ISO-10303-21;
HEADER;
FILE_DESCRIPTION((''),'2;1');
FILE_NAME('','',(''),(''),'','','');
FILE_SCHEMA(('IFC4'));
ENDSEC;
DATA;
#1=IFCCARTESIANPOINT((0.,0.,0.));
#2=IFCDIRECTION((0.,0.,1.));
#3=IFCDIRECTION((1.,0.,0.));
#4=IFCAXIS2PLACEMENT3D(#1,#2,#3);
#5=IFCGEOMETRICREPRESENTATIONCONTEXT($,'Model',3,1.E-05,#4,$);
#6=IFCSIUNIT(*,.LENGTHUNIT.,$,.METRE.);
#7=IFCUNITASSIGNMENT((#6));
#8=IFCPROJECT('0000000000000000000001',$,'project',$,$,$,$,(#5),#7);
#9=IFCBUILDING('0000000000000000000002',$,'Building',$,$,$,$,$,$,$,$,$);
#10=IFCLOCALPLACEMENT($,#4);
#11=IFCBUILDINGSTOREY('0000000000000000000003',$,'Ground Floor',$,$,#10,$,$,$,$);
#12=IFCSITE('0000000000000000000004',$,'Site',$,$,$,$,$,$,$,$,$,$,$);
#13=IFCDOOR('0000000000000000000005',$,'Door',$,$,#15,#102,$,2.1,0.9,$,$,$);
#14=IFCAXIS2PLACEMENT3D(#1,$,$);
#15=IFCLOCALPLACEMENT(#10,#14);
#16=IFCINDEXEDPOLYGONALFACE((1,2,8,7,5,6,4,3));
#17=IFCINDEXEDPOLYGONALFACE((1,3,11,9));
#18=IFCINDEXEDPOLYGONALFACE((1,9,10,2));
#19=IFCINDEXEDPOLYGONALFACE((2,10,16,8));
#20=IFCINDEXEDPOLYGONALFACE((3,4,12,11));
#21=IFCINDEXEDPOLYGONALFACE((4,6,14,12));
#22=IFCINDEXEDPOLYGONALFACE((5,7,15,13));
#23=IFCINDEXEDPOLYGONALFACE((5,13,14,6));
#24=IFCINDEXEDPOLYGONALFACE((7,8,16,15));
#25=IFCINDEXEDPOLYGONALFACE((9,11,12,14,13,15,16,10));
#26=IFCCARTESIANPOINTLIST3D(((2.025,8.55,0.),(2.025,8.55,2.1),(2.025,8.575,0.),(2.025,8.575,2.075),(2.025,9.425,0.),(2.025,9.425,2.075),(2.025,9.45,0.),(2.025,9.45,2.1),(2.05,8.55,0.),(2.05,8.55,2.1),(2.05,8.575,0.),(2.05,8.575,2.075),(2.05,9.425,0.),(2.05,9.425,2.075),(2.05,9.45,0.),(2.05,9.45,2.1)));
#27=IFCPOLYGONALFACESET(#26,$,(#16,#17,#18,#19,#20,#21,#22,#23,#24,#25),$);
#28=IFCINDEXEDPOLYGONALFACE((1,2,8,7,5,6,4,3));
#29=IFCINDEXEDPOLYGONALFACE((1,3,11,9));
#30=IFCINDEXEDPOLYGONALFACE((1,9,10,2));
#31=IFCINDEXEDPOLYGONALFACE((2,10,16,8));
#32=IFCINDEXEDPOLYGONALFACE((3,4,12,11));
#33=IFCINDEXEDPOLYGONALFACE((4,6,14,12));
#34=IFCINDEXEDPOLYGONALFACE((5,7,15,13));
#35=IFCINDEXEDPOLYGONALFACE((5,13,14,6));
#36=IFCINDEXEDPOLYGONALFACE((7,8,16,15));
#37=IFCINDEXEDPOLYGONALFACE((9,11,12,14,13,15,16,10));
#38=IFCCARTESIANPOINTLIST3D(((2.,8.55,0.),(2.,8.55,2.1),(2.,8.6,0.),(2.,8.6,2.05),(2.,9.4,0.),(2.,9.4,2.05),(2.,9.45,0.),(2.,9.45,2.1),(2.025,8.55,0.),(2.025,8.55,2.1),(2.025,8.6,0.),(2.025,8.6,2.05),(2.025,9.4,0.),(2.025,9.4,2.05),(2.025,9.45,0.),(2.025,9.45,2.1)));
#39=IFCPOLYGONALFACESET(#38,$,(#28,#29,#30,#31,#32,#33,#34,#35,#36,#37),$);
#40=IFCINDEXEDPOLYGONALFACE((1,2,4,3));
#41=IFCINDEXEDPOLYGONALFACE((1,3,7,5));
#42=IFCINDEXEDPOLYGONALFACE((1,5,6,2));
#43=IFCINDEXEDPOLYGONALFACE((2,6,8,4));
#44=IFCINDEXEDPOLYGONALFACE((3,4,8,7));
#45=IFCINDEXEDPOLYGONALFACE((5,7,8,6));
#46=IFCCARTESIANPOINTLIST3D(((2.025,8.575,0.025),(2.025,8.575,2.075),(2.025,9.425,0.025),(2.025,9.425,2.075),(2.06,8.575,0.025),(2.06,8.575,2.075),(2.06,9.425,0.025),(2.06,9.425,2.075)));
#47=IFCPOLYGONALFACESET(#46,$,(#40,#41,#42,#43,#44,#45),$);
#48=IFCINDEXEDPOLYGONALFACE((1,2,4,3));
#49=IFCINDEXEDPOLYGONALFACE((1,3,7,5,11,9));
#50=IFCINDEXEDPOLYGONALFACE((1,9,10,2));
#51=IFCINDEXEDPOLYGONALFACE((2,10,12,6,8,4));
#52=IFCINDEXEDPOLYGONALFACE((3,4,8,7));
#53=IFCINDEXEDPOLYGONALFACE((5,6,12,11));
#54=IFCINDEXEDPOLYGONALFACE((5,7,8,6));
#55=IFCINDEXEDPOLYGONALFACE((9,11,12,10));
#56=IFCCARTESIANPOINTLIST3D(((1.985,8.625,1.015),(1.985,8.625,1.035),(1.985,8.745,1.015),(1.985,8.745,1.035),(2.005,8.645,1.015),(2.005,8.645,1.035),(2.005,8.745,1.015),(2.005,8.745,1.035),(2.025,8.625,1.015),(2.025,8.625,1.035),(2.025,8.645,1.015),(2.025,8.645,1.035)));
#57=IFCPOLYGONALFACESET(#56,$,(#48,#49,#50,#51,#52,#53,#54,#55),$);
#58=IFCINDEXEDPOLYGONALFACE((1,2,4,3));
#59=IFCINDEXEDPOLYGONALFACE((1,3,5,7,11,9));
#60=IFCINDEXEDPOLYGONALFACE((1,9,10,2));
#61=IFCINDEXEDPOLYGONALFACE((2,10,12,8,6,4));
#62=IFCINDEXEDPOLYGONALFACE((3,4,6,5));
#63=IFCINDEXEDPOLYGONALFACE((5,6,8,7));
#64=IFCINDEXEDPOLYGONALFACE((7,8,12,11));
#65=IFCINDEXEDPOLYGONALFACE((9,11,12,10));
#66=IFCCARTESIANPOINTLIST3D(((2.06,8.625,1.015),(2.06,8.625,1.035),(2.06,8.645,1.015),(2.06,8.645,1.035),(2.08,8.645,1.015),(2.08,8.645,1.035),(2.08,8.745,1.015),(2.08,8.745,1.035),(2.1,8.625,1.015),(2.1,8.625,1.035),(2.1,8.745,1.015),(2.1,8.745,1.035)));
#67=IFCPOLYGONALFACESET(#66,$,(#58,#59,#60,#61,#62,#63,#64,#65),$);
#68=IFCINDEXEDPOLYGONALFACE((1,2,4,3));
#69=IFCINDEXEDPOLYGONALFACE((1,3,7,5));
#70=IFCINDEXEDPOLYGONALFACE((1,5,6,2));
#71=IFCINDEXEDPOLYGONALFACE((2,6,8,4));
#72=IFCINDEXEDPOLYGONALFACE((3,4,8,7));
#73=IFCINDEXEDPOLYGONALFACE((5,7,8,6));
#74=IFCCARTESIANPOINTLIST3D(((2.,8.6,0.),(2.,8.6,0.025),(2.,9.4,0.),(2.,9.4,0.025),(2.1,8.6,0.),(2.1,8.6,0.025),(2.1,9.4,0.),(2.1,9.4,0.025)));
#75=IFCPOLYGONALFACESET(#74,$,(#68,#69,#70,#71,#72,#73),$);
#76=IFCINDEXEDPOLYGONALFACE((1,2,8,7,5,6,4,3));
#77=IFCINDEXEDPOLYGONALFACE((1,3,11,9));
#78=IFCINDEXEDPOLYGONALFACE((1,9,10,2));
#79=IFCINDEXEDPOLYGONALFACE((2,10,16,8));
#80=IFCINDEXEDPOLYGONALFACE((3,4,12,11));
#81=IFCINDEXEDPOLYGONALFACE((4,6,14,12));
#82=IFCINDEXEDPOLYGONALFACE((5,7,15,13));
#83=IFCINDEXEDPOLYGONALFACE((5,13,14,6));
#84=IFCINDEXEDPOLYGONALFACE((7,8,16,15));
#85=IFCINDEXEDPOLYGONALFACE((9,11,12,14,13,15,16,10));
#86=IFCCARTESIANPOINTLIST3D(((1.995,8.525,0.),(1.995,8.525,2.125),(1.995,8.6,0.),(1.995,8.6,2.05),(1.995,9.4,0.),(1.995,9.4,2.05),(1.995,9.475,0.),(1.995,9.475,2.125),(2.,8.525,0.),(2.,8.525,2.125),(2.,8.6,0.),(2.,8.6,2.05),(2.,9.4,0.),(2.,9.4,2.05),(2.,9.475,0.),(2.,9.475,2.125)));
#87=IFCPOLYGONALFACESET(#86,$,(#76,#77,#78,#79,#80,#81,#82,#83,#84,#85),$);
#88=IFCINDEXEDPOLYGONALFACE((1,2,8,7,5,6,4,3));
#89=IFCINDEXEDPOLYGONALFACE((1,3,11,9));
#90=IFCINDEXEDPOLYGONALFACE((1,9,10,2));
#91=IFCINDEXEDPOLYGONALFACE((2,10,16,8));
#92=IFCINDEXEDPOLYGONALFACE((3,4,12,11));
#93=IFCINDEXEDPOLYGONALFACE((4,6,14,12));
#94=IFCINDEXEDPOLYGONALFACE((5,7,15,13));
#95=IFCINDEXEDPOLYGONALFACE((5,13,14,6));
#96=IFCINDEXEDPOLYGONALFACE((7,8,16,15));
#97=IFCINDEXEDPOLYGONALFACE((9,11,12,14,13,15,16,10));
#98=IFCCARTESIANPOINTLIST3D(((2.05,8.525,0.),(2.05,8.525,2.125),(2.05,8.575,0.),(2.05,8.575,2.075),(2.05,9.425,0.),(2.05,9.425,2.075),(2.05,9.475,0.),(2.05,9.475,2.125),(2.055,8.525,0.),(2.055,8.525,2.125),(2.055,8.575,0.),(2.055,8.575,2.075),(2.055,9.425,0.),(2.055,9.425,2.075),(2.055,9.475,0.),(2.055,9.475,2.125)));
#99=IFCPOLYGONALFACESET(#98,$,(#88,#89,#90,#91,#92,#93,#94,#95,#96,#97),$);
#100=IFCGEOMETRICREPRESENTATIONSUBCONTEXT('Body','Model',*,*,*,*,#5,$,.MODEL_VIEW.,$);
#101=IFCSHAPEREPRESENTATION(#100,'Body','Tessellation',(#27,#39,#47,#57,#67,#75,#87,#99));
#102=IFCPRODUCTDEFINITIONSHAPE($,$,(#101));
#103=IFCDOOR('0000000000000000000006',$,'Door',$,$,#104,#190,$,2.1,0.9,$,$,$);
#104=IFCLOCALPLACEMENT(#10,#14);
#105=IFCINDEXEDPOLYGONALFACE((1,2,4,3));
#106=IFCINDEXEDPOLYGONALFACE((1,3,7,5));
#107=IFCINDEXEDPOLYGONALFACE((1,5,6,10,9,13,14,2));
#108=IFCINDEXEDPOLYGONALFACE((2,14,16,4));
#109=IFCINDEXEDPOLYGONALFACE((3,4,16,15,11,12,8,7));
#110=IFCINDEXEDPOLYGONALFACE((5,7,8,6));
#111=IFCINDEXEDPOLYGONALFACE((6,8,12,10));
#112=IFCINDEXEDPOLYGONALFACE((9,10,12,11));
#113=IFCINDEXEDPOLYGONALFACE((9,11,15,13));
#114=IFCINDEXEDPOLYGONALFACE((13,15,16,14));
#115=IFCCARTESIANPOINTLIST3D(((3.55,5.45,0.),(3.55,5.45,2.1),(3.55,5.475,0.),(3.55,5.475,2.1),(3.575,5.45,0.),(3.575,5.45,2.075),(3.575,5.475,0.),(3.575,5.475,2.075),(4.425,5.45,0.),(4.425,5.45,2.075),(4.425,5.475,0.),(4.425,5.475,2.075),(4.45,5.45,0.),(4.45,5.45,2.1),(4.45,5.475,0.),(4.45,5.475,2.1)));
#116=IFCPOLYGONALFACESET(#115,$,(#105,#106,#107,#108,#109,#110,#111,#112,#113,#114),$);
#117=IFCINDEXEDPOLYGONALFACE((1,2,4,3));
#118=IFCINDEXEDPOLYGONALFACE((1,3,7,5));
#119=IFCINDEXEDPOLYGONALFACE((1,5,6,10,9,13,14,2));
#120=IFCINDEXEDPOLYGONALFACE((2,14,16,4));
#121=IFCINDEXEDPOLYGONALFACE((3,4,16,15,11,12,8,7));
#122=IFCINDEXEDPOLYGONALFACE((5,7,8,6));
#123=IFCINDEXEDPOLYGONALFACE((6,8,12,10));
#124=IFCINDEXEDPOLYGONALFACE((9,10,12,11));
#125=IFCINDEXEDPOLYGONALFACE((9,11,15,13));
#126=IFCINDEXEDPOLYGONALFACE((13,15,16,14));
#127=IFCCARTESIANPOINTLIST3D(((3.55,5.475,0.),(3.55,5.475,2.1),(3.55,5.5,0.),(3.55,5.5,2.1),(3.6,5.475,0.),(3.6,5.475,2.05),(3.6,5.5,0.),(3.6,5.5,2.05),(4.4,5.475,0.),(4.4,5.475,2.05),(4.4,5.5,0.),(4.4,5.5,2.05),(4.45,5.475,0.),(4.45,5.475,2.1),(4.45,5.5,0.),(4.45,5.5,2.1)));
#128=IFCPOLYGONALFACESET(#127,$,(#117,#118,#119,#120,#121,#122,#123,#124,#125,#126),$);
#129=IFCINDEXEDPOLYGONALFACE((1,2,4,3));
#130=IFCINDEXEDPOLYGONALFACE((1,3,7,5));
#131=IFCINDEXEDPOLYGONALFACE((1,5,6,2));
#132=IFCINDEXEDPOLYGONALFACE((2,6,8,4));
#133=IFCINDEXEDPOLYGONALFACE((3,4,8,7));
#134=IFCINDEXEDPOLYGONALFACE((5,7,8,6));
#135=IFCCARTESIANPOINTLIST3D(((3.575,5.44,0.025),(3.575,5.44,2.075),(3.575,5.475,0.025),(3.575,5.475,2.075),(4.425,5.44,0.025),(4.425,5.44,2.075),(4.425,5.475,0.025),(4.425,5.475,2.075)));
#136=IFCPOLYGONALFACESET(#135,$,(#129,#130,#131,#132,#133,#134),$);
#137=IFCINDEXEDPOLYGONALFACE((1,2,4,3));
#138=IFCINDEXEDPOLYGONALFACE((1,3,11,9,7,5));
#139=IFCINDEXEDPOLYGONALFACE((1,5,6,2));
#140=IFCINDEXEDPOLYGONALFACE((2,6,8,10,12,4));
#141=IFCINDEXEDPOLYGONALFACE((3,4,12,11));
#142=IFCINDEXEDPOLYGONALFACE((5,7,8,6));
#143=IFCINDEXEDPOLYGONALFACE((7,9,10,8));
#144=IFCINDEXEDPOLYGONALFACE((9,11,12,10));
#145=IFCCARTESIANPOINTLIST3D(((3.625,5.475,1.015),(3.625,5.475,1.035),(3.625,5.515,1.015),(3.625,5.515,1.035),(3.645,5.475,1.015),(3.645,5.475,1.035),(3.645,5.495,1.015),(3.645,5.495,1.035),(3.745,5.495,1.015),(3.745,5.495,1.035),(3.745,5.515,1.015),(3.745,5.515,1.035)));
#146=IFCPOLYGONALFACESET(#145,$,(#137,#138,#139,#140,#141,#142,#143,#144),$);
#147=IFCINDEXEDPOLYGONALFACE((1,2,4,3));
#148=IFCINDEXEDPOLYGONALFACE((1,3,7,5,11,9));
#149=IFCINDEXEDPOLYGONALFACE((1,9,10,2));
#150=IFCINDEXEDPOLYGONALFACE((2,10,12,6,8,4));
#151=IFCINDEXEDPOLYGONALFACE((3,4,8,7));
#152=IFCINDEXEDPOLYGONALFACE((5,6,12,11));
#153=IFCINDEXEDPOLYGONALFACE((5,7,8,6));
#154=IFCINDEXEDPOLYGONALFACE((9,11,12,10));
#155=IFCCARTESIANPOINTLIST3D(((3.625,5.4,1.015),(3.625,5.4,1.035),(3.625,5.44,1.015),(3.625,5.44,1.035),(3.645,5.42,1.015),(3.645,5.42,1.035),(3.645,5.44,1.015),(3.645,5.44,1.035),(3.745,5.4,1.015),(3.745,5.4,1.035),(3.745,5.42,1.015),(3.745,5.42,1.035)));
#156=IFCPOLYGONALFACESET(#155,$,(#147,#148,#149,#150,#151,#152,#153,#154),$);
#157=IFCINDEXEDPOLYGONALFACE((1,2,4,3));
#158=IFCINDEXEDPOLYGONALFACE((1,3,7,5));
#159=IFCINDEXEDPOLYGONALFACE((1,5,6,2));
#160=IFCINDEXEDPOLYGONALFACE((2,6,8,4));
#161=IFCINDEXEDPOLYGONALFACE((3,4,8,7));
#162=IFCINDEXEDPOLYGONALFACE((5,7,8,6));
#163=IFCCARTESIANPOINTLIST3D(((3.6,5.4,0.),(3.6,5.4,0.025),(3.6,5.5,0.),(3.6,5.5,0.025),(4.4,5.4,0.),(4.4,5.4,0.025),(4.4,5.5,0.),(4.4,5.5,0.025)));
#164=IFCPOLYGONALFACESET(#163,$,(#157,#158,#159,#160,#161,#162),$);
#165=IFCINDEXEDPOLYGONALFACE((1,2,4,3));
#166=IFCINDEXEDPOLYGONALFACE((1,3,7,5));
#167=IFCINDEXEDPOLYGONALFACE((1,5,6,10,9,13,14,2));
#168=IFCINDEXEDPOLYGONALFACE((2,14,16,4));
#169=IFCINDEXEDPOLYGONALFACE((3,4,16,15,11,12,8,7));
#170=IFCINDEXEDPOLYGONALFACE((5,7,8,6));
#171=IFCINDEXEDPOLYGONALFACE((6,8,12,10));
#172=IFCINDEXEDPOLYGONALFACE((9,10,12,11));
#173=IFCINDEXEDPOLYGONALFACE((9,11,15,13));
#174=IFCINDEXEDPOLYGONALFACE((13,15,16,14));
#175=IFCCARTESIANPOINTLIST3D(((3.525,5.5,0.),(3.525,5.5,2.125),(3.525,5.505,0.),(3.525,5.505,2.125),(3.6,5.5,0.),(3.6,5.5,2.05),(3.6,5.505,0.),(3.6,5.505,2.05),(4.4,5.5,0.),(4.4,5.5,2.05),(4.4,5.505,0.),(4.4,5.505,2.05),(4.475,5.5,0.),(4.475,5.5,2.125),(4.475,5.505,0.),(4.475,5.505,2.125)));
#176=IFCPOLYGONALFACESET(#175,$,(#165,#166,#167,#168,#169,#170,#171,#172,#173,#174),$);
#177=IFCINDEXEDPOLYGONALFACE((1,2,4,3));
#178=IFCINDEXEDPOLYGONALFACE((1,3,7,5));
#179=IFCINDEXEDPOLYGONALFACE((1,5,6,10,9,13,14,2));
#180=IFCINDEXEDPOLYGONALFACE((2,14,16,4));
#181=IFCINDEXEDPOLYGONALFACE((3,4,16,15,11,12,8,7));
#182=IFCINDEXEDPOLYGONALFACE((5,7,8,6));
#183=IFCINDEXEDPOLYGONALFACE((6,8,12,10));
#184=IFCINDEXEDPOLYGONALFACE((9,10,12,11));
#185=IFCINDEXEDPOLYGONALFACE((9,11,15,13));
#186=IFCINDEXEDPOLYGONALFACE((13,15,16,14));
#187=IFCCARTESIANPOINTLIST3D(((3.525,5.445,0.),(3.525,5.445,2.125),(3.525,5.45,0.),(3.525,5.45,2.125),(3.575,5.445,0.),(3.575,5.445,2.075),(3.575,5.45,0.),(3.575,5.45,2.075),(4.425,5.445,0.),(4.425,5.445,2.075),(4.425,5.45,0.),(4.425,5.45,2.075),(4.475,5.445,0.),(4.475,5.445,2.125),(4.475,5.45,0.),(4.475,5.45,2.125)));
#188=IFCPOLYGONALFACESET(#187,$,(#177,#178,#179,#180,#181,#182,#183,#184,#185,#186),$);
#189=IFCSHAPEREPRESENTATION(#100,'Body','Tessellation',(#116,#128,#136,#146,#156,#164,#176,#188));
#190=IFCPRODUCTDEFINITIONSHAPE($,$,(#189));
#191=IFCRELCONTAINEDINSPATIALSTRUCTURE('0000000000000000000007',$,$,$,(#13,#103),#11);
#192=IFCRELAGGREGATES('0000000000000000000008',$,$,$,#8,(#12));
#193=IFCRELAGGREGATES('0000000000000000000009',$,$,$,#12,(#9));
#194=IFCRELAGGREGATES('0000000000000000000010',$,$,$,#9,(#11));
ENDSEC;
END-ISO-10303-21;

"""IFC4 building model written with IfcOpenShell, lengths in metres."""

from ifc_helpers import new_model, si_unit, frame, origin_with_axes, place, context, subcontext, project, spatial, line, indexed_curve, outline, extrude, element, save


model = new_model("IFC4")

# Units and contexts
model_context = context("Model", 3, precision=1e-05, world=origin_with_axes())
body_context = subcontext(model_context, "Body", "Model", "MODEL_VIEW")
ifc_project = project(units=[si_unit("LENGTHUNIT", "METRE")], contexts=[model_context])

# Site, building, storey
site = spatial("IfcSite", under=ifc_project, Name="Site")
building = spatial("IfcBuilding", under=site, Name="Building")
storey_placement = place(None, origin_with_axes())
storey = spatial("IfcBuildingStorey", under=building, at=storey_placement, Name="Ground Floor")

# Doors
door_1_placement = place(storey_placement, frame((2.0, 9.45, 0.0), z_axis=(0.0, 0.0, 1.0), x_axis=(0.0, -1.0, 0.0)))
element("IfcDoor", 1, at=door_1_placement, inside=storey, Name="Door", OverallHeight=2.1, OverallWidth=0.9, context=body_context, shape_type="SweptSolid", body=[
    extrude(outline(indexed_curve([(0.0, 0.0), (0.0, 2.1), (0.9, 2.1), (0.9, 0.0), (0.875, 0.0), (0.875, 2.075), (0.025, 2.075), (0.025, 0.0)], segments=[line(1, 2, 3, 4, 5, 6, 7, 8, 1)])), frame((0.0, 0.025, 0.0), z_axis=(0.0, -1.0, 0.0), x_axis=(1.0, 0.0, 0.0)), (0.0, 0.0, -1.0), 0.025),
    extrude(outline(indexed_curve([(0.0, 0.0), (0.0, 2.1), (0.9, 2.1), (0.9, 0.0), (0.85, 0.0), (0.85, 2.05), (0.05, 2.05), (0.05, 0.0)], segments=[line(1, 2, 3, 4, 5, 6, 7, 8, 1)])), frame((0.0, 0.0, 0.0), z_axis=(0.0, -1.0, 0.0), x_axis=(1.0, 0.0, 0.0)), (0.0, 0.0, -1.0), 0.025),
    extrude(outline(indexed_curve([(0.0, 0.0), (0.85, 0.0), (0.85, 0.035), (0.0, 0.035)], segments=[line(1, 2, 3, 4, 1)])), frame((0.025, 0.025, 0.025), z_axis=(0.0, 0.0, 1.0), x_axis=(1.0, 0.0, 0.0)), (0.0, 0.0, 1.0), 2.05),
    extrude(outline(indexed_curve([(0.0, 0.0), (0.0, -0.04), (-0.12, -0.04), (-0.12, -0.02), (-0.02, -0.02), (-0.02, 0.0)], segments=[line(1, 2, 3, 4, 5, 6, 1)])), frame((0.825, 0.025, 1.015), z_axis=(0.0, 0.0, 1.0), x_axis=(1.0, 0.0, 0.0)), (0.0, 0.0, 1.0), 0.02),
    extrude(outline(indexed_curve([(0.0, 0.0), (0.0, 0.04), (-0.12, 0.04), (-0.12, 0.02), (-0.02, 0.02), (-0.02, 0.0)], segments=[line(1, 2, 3, 4, 5, 6, 1)])), frame((0.825, 0.06, 1.015), z_axis=(0.0, 0.0, 1.0), x_axis=(1.0, 0.0, 0.0)), (0.0, 0.0, 1.0), 0.02),
    extrude(outline(indexed_curve([(0.0, 0.0), (0.8, 0.0), (0.8, 0.1), (0.0, 0.1)], segments=[line(1, 2, 3, 4, 1)])), frame((0.05, 0.0, 0.0), z_axis=(0.0, 0.0, 1.0), x_axis=(1.0, 0.0, 0.0)), (0.0, 0.0, 1.0), 0.025),
    extrude(outline(indexed_curve([(0.0, 0.0), (0.0, 2.125), (0.95, 2.125), (0.95, 0.0), (0.875, 0.0), (0.875, 2.05), (0.075, 2.05), (0.075, 0.0)], segments=[line(1, 2, 3, 4, 5, 6, 7, 8, 1)])), frame((-0.025, -0.005, 0.0), z_axis=(0.0, -1.0, 0.0), x_axis=(1.0, 0.0, 0.0)), (0.0, 0.0, -1.0), 0.005),
    extrude(outline(indexed_curve([(0.0, 0.0), (0.0, 2.125), (0.95, 2.125), (0.95, 0.0), (0.9, 0.0), (0.9, 2.075), (0.05, 2.075), (0.05, 0.0)], segments=[line(1, 2, 3, 4, 5, 6, 7, 8, 1)])), frame((-0.025, 0.05, 0.0), z_axis=(0.0, -1.0, 0.0), x_axis=(1.0, 0.0, 0.0)), (0.0, 0.0, -1.0), 0.005),
])
door_2_placement = place(storey_placement, frame((4.45, 5.5, 0.0), z_axis=(0.0, 0.0, 1.0), x_axis=(-1.0, 0.0, 0.0)))
element("IfcDoor", 2, at=door_2_placement, inside=storey, Name="Door", OverallHeight=2.1, OverallWidth=0.9, context=body_context, shape_type="SweptSolid", body=[
    extrude(outline(indexed_curve([(0.0, 0.0), (0.0, 2.1), (0.9, 2.1), (0.9, 0.0), (0.875, 0.0), (0.875, 2.075), (0.025, 2.075), (0.025, 0.0)], segments=[line(1, 2, 3, 4, 5, 6, 7, 8, 1)])), frame((0.0, 0.025, 0.0), z_axis=(0.0, -1.0, 0.0), x_axis=(1.0, 0.0, 0.0)), (0.0, 0.0, -1.0), 0.025),
    extrude(outline(indexed_curve([(0.0, 0.0), (0.0, 2.1), (0.9, 2.1), (0.9, 0.0), (0.85, 0.0), (0.85, 2.05), (0.05, 2.05), (0.05, 0.0)], segments=[line(1, 2, 3, 4, 5, 6, 7, 8, 1)])), frame((0.0, 0.0, 0.0), z_axis=(0.0, -1.0, 0.0), x_axis=(1.0, 0.0, 0.0)), (0.0, 0.0, -1.0), 0.025),
    extrude(outline(indexed_curve([(0.0, 0.0), (0.85, 0.0), (0.85, 0.035), (0.0, 0.035)], segments=[line(1, 2, 3, 4, 1)])), frame((0.025, 0.025, 0.025), z_axis=(0.0, 0.0, 1.0), x_axis=(1.0, 0.0, 0.0)), (0.0, 0.0, 1.0), 2.05),
    extrude(outline(indexed_curve([(0.0, 0.0), (0.0, -0.04), (-0.12, -0.04), (-0.12, -0.02), (-0.02, -0.02), (-0.02, 0.0)], segments=[line(1, 2, 3, 4, 5, 6, 1)])), frame((0.825, 0.025, 1.015), z_axis=(0.0, 0.0, 1.0), x_axis=(1.0, 0.0, 0.0)), (0.0, 0.0, 1.0), 0.02),
    extrude(outline(indexed_curve([(0.0, 0.0), (0.0, 0.04), (-0.12, 0.04), (-0.12, 0.02), (-0.02, 0.02), (-0.02, 0.0)], segments=[line(1, 2, 3, 4, 5, 6, 1)])), frame((0.825, 0.06, 1.015), z_axis=(0.0, 0.0, 1.0), x_axis=(1.0, 0.0, 0.0)), (0.0, 0.0, 1.0), 0.02),
    extrude(outline(indexed_curve([(0.0, 0.0), (0.8, 0.0), (0.8, 0.1), (0.0, 0.1)], segments=[line(1, 2, 3, 4, 1)])), frame((0.05, 0.0, 0.0), z_axis=(0.0, 0.0, 1.0), x_axis=(1.0, 0.0, 0.0)), (0.0, 0.0, 1.0), 0.025),
    extrude(outline(indexed_curve([(0.0, 0.0), (0.0, 2.125), (0.95, 2.125), (0.95, 0.0), (0.875, 0.0), (0.875, 2.05), (0.075, 2.05), (0.075, 0.0)], segments=[line(1, 2, 3, 4, 5, 6, 7, 8, 1)])), frame((-0.025, -0.005, 0.0), z_axis=(0.0, -1.0, 0.0), x_axis=(1.0, 0.0, 0.0)), (0.0, 0.0, -1.0), 0.005),
    extrude(outline(indexed_curve([(0.0, 0.0), (0.0, 2.125), (0.95, 2.125), (0.95, 0.0), (0.9, 0.0), (0.9, 2.075), (0.05, 2.075), (0.05, 0.0)], segments=[line(1, 2, 3, 4, 5, 6, 7, 8, 1)])), frame((-0.025, 0.05, 0.0), z_axis=(0.0, -1.0, 0.0), x_axis=(1.0, 0.0, 0.0)), (0.0, 0.0, -1.0), 0.005),
])

save(model, "model.ifc")
